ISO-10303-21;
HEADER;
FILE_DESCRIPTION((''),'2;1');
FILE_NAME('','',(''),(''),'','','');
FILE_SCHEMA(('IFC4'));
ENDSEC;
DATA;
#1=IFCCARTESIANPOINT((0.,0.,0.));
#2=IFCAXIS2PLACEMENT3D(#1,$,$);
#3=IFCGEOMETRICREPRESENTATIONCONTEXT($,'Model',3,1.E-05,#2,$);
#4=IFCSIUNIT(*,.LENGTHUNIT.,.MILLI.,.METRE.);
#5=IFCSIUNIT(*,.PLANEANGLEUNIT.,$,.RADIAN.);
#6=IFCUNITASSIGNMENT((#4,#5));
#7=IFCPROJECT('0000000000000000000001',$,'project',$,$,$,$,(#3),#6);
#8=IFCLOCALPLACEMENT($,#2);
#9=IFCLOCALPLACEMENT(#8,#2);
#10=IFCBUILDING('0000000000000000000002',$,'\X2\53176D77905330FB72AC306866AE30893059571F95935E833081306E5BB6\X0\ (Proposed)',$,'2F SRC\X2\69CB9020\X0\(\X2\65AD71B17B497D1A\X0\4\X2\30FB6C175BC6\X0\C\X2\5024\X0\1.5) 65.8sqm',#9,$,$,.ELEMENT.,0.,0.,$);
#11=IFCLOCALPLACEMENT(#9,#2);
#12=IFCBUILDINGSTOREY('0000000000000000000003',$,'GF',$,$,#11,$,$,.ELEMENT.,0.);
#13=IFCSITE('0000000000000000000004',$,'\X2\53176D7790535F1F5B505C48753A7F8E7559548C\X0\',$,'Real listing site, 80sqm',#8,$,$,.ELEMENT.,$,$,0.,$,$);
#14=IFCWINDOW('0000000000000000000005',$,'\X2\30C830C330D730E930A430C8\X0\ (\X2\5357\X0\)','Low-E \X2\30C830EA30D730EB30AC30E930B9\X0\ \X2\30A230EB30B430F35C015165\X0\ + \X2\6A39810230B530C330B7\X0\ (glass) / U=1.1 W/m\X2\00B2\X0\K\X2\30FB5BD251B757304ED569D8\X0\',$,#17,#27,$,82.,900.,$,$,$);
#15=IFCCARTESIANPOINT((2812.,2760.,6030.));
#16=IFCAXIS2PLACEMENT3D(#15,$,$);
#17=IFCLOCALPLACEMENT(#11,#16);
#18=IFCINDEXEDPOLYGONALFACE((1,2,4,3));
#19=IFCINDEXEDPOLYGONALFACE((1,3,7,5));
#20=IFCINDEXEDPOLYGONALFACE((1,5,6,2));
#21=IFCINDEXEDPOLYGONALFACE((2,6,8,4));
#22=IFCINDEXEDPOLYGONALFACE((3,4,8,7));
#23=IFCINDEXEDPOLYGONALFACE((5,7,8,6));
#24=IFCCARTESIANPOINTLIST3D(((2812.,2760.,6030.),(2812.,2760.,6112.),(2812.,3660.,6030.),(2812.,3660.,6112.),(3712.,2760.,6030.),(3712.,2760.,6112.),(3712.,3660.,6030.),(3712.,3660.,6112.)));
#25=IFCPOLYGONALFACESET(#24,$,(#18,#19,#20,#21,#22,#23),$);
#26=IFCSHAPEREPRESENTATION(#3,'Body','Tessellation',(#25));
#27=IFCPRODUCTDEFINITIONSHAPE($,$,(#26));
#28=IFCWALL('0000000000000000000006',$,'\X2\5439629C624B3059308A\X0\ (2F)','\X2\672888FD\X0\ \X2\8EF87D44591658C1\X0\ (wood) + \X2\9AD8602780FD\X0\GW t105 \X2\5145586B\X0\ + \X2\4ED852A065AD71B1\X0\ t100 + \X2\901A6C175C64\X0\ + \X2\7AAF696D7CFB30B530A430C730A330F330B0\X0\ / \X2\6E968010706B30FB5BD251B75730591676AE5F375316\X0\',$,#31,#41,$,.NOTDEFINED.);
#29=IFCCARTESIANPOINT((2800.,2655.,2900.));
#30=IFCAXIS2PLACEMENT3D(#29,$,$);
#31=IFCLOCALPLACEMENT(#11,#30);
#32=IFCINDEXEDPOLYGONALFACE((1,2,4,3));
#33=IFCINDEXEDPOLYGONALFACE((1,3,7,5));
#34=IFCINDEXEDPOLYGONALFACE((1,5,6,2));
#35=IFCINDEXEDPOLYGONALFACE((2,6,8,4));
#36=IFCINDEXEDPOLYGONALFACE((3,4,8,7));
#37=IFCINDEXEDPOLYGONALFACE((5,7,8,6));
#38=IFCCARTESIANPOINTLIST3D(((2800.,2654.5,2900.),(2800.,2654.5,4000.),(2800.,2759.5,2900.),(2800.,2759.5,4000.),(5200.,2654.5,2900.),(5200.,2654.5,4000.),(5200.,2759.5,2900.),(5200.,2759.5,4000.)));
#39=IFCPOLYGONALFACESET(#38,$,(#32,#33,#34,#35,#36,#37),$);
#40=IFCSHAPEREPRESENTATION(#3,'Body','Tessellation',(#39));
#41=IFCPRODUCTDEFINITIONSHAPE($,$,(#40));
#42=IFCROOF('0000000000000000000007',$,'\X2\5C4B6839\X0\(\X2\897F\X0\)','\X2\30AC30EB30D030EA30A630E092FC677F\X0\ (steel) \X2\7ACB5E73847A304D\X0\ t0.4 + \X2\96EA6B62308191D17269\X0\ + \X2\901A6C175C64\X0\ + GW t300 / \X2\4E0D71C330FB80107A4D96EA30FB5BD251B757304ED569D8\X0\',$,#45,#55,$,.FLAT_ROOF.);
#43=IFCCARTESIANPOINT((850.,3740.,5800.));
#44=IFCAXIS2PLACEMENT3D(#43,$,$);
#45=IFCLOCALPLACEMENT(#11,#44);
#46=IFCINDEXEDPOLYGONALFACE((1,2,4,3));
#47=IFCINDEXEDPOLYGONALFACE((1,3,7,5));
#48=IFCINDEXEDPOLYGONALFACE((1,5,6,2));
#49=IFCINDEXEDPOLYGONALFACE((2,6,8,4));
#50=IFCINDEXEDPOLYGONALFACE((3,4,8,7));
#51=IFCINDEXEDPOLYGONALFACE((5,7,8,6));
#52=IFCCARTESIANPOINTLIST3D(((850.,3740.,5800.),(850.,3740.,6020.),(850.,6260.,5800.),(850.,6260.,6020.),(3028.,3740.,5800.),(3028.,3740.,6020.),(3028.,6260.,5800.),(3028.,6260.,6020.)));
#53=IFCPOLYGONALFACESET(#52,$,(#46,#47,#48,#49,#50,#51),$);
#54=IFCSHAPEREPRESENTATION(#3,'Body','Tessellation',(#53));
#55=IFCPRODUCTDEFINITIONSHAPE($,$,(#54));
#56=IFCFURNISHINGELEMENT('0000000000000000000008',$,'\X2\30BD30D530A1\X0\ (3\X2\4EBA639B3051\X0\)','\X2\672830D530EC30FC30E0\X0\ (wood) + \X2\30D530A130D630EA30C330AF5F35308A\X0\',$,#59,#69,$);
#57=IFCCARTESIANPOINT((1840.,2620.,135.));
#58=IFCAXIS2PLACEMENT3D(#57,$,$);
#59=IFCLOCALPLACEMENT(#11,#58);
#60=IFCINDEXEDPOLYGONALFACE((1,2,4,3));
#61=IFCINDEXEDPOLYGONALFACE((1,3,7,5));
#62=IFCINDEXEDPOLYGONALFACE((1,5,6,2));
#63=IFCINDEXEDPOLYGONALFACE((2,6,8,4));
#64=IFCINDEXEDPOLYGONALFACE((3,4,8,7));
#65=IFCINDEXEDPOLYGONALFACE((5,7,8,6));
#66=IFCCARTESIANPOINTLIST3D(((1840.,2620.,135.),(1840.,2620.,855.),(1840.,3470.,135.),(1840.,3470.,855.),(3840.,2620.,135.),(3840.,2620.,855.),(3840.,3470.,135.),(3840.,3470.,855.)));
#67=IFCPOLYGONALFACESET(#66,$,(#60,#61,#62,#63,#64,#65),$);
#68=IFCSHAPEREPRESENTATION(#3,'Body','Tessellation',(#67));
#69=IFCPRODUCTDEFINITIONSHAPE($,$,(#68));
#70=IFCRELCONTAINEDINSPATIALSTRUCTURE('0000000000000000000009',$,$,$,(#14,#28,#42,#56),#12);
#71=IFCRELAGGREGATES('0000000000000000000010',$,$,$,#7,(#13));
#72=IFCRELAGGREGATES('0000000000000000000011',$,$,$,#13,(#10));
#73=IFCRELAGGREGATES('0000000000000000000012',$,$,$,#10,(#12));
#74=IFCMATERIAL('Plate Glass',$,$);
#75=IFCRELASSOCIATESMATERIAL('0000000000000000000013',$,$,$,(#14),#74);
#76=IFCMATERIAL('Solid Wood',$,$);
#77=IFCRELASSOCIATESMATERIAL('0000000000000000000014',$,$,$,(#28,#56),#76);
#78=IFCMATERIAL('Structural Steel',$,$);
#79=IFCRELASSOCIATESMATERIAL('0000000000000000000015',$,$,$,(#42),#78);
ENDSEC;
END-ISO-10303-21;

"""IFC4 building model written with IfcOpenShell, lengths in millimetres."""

from ifc_helpers import new_model, si_unit, frame, frame_2d, origin, place, context, project, spatial, rectangle, extrude, material, element, save


model = new_model("IFC4")

# Units and contexts
model_context = context("Model", 3, precision=1e-05, world=origin())
ifc_project = project(units=[si_unit("LENGTHUNIT", "METRE", prefix="MILLI"), si_unit("PLANEANGLEUNIT", "RADIAN")], contexts=[model_context])

# Site, building, storey
site_placement = place(None, origin())
site = spatial("IfcSite", under=ifc_project, at=site_placement, Name="北海道弟子屈町美留和", ObjectType="Real listing site, 80sqm", CompositionType="ELEMENT", RefElevation=0.0)
building_placement = place(site_placement, origin())
building = spatial("IfcBuilding", under=site, at=building_placement, Name="北海道・犬と暮らす土間広めの家 (Proposed)", ObjectType="2F SRC構造(断熱等級4・気密C値1.5) 65.8sqm", CompositionType="ELEMENT", ElevationOfRefHeight=0.0, ElevationOfTerrain=0.0)
storey_placement = place(building_placement, origin())
storey = spatial("IfcBuildingStorey", under=building, at=storey_placement, Name="GF", CompositionType="ELEMENT", Elevation=0.0)

# Shared definitions
ifc_material_1 = material(Name="Solid Wood")

# Shared definitions
ifc_material_2 = material(Name="Plate Glass")

# Window
window_1_placement = place(storey_placement, frame((2812.0, 2760.0, 6030.0)))
element("IfcWindow", 1, at=window_1_placement, inside=storey, material=ifc_material_2, Name="トップライト (南)", Description="Low-E トリプルガラス アルゴン封入 + 樹脂サッシ (glass) / U=1.1 W/m²K・寒冷地仕様", OverallHeight=82.0, OverallWidth=900.0, context=model_context, shape_type="SweptSolid", body=[
    extrude(rectangle(XDim=900.0, YDim=900.0, at=frame_2d((450.0, 450.0))), frame((2812.0, 2760.0, 6030.0)), (0.0, 0.0, 1.0), 82.0),
])

# Wall
wall_1_placement = place(storey_placement, frame((2800.0, 2655.0, 2900.0)))
element("IfcWall", 2, at=wall_1_placement, inside=storey, material=ifc_material_1, Name="吹抜手すり (2F)", Description="木製 軸組外壁 (wood) + 高性能GW t105 充填 + 付加断熱 t100 + 通気層 + 窯業系サイディング / 準耐火・寒冷地外皮強化", PredefinedType="NOTDEFINED", context=model_context, shape_type="SweptSolid", body=[
    extrude(rectangle(XDim=2400.0, YDim=105.0, at=frame_2d((1200.0, 52.0))), frame((2800.0, 2655.0, 2900.0)), (0.0, 0.0, 1.0), 1100.0),
])

# Roof
ifc_material_3 = material(Name="Structural Steel")
for number, where, name in (
    (3, (850.0, 3740.0, 5800.0), "屋根(西)"),
):
    element("IfcRoof", number, at=place(storey_placement, frame(where)), inside=storey, material=ifc_material_3, Name=name, Description="ガルバリウム鋼板 (steel) 立平葺き t0.4 + 雪止め金物 + 通気層 + GW t300 / 不燃・耐積雪・寒冷地仕様", PredefinedType="FLAT_ROOF", context=model_context, shape_type="SweptSolid", body=[
        extrude(rectangle(XDim=2178.0, YDim=2520.0, at=frame_2d((1089.0, 1260.0))), frame((850.0, 3740.0, 5800.0)), (0.0, 0.0, 1.0), 220.0),
    ])

# Furnishing element
furnishing_placement = place(storey_placement, frame((1840.0, 2620.0, 135.0)))
element("IfcFurnishingElement", 4, at=furnishing_placement, inside=storey, material=ifc_material_1, Name="ソファ (3人掛け)", Description="木フレーム (wood) + ファブリック張り", context=model_context, shape_type="SweptSolid", body=[
    extrude(rectangle(XDim=2000.0, YDim=850.0, at=frame_2d((1000.0, 425.0))), frame((1840.0, 2620.0, 135.0)), (0.0, 0.0, 1.0), 720.0),
])

save(model, "model.ifc")
